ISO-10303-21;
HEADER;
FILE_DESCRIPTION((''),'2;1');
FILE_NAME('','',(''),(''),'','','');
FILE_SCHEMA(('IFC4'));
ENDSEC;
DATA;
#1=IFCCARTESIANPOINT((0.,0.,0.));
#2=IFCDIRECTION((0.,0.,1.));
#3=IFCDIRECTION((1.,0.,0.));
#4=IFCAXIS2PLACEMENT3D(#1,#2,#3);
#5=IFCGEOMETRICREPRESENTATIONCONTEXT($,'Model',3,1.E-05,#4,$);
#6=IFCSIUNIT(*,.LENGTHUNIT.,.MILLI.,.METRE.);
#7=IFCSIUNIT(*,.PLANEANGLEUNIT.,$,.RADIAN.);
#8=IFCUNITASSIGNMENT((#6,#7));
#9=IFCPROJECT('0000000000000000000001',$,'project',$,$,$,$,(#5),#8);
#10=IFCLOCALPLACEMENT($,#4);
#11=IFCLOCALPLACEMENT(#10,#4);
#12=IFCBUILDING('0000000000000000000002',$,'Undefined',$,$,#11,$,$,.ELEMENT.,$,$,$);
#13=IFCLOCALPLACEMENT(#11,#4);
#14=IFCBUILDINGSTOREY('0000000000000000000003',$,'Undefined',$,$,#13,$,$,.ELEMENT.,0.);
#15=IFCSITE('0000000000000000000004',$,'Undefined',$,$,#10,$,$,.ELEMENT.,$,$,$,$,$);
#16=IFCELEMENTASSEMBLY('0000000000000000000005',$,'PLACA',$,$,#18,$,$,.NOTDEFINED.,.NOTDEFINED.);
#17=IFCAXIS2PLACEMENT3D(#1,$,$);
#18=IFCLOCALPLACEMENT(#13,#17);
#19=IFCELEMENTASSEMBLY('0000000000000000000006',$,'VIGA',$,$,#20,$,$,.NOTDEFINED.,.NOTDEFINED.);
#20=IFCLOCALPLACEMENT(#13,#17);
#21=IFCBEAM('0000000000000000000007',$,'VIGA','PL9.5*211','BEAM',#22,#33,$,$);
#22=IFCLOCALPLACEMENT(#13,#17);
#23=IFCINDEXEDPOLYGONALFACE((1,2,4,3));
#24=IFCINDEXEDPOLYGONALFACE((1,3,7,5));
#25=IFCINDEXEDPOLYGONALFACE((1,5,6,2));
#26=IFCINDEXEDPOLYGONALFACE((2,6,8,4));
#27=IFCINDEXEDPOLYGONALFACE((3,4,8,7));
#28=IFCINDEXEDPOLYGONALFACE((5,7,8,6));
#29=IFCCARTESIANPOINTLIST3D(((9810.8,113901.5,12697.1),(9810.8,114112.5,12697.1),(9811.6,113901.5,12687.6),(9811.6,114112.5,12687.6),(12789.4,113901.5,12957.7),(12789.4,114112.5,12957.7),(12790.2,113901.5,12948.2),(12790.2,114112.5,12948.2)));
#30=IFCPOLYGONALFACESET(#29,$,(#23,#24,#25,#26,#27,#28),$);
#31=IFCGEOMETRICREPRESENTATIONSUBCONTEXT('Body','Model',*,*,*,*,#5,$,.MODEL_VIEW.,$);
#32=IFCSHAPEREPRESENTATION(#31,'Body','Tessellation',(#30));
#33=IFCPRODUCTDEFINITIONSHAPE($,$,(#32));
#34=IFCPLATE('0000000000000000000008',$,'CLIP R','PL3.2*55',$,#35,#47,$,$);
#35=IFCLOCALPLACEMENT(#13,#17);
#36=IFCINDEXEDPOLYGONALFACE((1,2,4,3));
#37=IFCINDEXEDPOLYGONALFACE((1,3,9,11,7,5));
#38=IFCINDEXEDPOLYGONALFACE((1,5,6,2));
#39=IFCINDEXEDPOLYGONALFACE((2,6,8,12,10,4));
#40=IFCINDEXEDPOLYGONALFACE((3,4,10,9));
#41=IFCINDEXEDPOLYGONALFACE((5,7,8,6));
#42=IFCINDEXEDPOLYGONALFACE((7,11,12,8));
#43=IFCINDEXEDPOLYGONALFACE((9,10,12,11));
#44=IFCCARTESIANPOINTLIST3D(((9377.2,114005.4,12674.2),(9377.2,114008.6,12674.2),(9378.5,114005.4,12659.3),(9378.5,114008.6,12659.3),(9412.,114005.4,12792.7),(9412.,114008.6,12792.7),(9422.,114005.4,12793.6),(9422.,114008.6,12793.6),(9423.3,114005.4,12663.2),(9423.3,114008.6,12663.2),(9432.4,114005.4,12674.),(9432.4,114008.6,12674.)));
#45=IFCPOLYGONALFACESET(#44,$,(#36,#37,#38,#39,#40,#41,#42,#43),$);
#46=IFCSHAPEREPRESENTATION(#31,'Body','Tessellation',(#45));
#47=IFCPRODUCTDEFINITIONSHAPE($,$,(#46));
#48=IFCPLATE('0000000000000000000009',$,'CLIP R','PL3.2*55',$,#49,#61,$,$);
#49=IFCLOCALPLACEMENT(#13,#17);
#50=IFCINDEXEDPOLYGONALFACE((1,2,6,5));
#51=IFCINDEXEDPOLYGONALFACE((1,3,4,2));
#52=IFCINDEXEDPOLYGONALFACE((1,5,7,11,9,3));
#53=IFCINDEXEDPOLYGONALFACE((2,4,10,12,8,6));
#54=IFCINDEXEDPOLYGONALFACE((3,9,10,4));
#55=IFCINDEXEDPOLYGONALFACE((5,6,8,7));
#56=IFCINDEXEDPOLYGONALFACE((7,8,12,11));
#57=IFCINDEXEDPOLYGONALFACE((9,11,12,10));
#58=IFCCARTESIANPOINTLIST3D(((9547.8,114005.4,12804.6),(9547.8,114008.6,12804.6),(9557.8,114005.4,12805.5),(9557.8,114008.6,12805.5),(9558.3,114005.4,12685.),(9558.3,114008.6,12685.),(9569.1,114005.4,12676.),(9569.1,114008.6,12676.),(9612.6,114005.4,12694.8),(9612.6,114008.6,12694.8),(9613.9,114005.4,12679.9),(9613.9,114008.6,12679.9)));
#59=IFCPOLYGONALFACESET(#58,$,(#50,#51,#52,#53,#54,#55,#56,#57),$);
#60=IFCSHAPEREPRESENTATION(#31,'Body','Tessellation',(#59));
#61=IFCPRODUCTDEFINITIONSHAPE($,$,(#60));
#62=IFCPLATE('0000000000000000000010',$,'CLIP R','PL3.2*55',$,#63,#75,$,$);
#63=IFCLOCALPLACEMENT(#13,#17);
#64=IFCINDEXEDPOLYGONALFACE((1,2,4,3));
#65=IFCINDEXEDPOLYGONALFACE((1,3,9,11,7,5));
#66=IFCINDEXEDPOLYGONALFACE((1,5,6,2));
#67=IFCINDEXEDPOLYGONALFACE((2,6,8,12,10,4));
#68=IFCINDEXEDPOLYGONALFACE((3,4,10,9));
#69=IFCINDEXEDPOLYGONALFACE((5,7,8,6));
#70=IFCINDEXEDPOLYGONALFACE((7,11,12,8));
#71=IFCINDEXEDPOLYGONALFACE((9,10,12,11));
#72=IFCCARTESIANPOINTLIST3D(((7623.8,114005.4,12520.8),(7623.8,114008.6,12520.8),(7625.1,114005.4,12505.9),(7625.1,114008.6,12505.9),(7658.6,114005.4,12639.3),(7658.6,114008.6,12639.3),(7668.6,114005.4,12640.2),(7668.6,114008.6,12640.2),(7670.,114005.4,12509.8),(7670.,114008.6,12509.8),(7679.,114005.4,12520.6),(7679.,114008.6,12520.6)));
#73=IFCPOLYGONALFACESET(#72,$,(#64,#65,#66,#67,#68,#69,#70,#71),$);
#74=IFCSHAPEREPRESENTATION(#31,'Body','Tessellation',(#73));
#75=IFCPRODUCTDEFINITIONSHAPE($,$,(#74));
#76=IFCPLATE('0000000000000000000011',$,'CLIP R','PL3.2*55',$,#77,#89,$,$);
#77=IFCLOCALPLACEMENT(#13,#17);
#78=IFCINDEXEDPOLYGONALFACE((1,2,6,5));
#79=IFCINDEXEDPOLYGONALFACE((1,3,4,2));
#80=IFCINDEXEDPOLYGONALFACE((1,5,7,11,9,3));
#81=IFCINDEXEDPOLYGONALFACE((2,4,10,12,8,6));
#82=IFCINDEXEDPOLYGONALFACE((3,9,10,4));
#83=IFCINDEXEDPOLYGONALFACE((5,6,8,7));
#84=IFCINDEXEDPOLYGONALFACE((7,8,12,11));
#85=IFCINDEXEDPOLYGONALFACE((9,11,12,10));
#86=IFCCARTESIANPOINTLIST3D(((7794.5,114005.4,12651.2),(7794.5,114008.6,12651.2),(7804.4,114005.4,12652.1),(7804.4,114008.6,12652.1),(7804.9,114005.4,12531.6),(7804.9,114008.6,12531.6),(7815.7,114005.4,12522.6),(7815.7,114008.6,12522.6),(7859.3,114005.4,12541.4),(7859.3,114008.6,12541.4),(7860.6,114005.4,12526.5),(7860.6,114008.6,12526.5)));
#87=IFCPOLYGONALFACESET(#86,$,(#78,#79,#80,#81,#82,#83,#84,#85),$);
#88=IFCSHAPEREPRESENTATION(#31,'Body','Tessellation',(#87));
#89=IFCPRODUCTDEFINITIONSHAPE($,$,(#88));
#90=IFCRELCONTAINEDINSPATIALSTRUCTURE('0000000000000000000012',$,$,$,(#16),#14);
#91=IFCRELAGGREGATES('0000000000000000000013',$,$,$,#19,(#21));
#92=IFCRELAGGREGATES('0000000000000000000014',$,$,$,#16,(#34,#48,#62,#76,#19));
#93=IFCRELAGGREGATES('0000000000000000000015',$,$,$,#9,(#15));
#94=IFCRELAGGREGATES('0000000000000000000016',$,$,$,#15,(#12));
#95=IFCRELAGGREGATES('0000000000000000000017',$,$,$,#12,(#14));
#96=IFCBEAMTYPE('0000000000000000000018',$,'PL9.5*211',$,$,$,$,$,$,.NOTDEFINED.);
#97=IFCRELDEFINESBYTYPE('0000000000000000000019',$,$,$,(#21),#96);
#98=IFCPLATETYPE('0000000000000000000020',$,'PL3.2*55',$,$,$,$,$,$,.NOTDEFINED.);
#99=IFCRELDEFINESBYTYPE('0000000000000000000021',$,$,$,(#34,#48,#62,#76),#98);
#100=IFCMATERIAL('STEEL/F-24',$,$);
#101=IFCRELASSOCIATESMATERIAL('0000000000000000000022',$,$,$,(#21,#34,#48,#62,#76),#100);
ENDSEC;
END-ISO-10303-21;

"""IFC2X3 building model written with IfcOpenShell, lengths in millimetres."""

from ifc_helpers import new_model, si_unit, frame, origin_with_axes, origin_2d_with_axis, place, context, subcontext, project, spatial, polyline, rectangle, outline, extrude, material, type_object, element, aggregate, save


model = new_model("IFC2X3")

# Units and contexts
model_context = context("Model", 3, precision=1e-05, world=origin_with_axes())
body_context = subcontext(model_context, "Body", "Model", "MODEL_VIEW")
ifc_project = project(units=[si_unit("LENGTHUNIT", "METRE", prefix="MILLI"), si_unit("PLANEANGLEUNIT", "RADIAN")], contexts=[model_context])

# Site, building, storey
site_placement = place(None, origin_with_axes())
site = spatial("IfcSite", under=ifc_project, at=site_placement, Name="Undefined", CompositionType="ELEMENT")
building_placement = place(site_placement, origin_with_axes())
building = spatial("IfcBuilding", under=site, at=building_placement, Name="Undefined", CompositionType="ELEMENT")
storey_placement = place(building_placement, origin_with_axes())
storey = spatial("IfcBuildingStorey", under=building, at=storey_placement, Name="Undefined", CompositionType="ELEMENT", Elevation=0.0)

# Shared definitions
ifc_material_1 = material(Name="STEEL/F-24")

# Element assemblies, beam, plates
assembly_1_placement = place(storey_placement, origin_with_axes())
assembly_1 = element("IfcElementAssembly", 1, at=assembly_1_placement, inside=storey, Name="PLACA", AssemblyPlace="NOTDEFINED", PredefinedType="NOTDEFINED")
assembly_2_placement = place(assembly_1_placement, origin_with_axes())
assembly_2 = element("IfcElementAssembly", 2, at=assembly_2_placement, Name="VIGA", AssemblyPlace="NOTDEFINED", PredefinedType="NOTDEFINED")
beam_type_1 = type_object("IfcBeamType", Name="PL9.5*211", PredefinedType="NOTDEFINED")
beam_1_placement = place(assembly_2_placement, frame((9811.2, 114007.0, 12692.4), z_axis=(0.0, -1.0, 0.0), x_axis=(0.996195, 0.0, 0.087155)))
beam_1 = element("IfcBeam", 3, at=beam_1_placement, type_object=beam_type_1, material=ifc_material_1, Name="VIGA", Description="PL9.5*211", ObjectType="BEAM", context=body_context, shape_type="SweptSolid", body=[
    extrude(rectangle(XDim=9.5, YDim=211.0, at=origin_2d_with_axis()), frame((2990.0, 0.0, 0.0), z_axis=(-1.0, 0.0, 0.0), x_axis=(0.0, -1.0, 0.0)), (0.0, 0.0, 1.0), 2990.0),
])
aggregate(assembly_2, [beam_1])
plate_type = type_object("IfcPlateType", Name="PL3.2*55", PredefinedType="NOTDEFINED")
plate_1_placement = place(assembly_1_placement, frame((9422.0, 114007.0, 12793.6), z_axis=(0.0, -1.0, 0.0), x_axis=(-0.996195, 0.0, -0.087155)))
plate_1 = element("IfcPlate", 4, at=plate_1_placement, type_object=plate_type, material=ifc_material_1, Name="CLIP R", Description="PL3.2*55", context=body_context, shape_type="SweptSolid", body=[
    extrude(outline(polyline([(0.0, 0.0), (10.0, 0.0), (55.0, 115.0), (55.0, 130.0), (10.0, 130.0), (0.0, 120.0), (0.0, 0.0)])), frame((0.0, 0.0, -1.6), z_axis=(0.0, 0.0, 1.0), x_axis=(1.0, 0.0, 0.0)), (0.0, 0.0, 1.0), 3.2),
])
plate_2_placement = place(assembly_1_placement, frame((9547.8, 114007.0, 12804.6), z_axis=(0.0, 1.0, 0.0), x_axis=(0.996195, 0.0, 0.087155)))
plate_2 = element("IfcPlate", 5, at=plate_2_placement, type_object=plate_type, material=ifc_material_1, Name="CLIP R", Description="PL3.2*55", context=body_context, shape_type="SweptSolid", body=[
    extrude(outline(polyline([(0.0, 0.0), (10.0, 0.0), (55.0, 115.0), (55.0, 130.0), (10.0, 130.0), (0.0, 120.0), (0.0, 0.0)])), frame((0.0, 0.0, -1.6), z_axis=(0.0, 0.0, 1.0), x_axis=(1.0, 0.0, 0.0)), (0.0, 0.0, 1.0), 3.2),
])
plate_3_placement = place(assembly_1_placement, frame((7668.6, 114007.0, 12640.2), z_axis=(0.0, -1.0, 0.0), x_axis=(-0.996195, 0.0, -0.087155)))
plate_3 = element("IfcPlate", 6, at=plate_3_placement, type_object=plate_type, material=ifc_material_1, Name="CLIP R", Description="PL3.2*55", context=body_context, shape_type="SweptSolid", body=[
    extrude(outline(polyline([(0.0, 0.0), (10.0, 0.0), (55.0, 115.0), (55.0, 130.0), (10.0, 130.0), (0.0, 120.0), (0.0, 0.0)])), frame((0.0, 0.0, -1.6), z_axis=(0.0, 0.0, 1.0), x_axis=(1.0, 0.0, 0.0)), (0.0, 0.0, 1.0), 3.2),
])
plate_4_placement = place(assembly_1_placement, frame((7794.5, 114007.0, 12651.2), z_axis=(0.0, 1.0, 0.0), x_axis=(0.996195, 0.0, 0.087155)))
plate_4 = element("IfcPlate", 7, at=plate_4_placement, type_object=plate_type, material=ifc_material_1, Name="CLIP R", Description="PL3.2*55", context=body_context, shape_type="SweptSolid", body=[
    extrude(outline(polyline([(0.0, 0.0), (10.0, 0.0), (55.0, 115.0), (55.0, 130.0), (10.0, 130.0), (0.0, 120.0), (0.0, 0.0)])), frame((0.0, 0.0, -1.6), z_axis=(0.0, 0.0, 1.0), x_axis=(1.0, 0.0, 0.0)), (0.0, 0.0, 1.0), 3.2),
])
aggregate(assembly_1, [plate_1, plate_2, plate_3, plate_4, assembly_2])

save(model, "model.ifc")
